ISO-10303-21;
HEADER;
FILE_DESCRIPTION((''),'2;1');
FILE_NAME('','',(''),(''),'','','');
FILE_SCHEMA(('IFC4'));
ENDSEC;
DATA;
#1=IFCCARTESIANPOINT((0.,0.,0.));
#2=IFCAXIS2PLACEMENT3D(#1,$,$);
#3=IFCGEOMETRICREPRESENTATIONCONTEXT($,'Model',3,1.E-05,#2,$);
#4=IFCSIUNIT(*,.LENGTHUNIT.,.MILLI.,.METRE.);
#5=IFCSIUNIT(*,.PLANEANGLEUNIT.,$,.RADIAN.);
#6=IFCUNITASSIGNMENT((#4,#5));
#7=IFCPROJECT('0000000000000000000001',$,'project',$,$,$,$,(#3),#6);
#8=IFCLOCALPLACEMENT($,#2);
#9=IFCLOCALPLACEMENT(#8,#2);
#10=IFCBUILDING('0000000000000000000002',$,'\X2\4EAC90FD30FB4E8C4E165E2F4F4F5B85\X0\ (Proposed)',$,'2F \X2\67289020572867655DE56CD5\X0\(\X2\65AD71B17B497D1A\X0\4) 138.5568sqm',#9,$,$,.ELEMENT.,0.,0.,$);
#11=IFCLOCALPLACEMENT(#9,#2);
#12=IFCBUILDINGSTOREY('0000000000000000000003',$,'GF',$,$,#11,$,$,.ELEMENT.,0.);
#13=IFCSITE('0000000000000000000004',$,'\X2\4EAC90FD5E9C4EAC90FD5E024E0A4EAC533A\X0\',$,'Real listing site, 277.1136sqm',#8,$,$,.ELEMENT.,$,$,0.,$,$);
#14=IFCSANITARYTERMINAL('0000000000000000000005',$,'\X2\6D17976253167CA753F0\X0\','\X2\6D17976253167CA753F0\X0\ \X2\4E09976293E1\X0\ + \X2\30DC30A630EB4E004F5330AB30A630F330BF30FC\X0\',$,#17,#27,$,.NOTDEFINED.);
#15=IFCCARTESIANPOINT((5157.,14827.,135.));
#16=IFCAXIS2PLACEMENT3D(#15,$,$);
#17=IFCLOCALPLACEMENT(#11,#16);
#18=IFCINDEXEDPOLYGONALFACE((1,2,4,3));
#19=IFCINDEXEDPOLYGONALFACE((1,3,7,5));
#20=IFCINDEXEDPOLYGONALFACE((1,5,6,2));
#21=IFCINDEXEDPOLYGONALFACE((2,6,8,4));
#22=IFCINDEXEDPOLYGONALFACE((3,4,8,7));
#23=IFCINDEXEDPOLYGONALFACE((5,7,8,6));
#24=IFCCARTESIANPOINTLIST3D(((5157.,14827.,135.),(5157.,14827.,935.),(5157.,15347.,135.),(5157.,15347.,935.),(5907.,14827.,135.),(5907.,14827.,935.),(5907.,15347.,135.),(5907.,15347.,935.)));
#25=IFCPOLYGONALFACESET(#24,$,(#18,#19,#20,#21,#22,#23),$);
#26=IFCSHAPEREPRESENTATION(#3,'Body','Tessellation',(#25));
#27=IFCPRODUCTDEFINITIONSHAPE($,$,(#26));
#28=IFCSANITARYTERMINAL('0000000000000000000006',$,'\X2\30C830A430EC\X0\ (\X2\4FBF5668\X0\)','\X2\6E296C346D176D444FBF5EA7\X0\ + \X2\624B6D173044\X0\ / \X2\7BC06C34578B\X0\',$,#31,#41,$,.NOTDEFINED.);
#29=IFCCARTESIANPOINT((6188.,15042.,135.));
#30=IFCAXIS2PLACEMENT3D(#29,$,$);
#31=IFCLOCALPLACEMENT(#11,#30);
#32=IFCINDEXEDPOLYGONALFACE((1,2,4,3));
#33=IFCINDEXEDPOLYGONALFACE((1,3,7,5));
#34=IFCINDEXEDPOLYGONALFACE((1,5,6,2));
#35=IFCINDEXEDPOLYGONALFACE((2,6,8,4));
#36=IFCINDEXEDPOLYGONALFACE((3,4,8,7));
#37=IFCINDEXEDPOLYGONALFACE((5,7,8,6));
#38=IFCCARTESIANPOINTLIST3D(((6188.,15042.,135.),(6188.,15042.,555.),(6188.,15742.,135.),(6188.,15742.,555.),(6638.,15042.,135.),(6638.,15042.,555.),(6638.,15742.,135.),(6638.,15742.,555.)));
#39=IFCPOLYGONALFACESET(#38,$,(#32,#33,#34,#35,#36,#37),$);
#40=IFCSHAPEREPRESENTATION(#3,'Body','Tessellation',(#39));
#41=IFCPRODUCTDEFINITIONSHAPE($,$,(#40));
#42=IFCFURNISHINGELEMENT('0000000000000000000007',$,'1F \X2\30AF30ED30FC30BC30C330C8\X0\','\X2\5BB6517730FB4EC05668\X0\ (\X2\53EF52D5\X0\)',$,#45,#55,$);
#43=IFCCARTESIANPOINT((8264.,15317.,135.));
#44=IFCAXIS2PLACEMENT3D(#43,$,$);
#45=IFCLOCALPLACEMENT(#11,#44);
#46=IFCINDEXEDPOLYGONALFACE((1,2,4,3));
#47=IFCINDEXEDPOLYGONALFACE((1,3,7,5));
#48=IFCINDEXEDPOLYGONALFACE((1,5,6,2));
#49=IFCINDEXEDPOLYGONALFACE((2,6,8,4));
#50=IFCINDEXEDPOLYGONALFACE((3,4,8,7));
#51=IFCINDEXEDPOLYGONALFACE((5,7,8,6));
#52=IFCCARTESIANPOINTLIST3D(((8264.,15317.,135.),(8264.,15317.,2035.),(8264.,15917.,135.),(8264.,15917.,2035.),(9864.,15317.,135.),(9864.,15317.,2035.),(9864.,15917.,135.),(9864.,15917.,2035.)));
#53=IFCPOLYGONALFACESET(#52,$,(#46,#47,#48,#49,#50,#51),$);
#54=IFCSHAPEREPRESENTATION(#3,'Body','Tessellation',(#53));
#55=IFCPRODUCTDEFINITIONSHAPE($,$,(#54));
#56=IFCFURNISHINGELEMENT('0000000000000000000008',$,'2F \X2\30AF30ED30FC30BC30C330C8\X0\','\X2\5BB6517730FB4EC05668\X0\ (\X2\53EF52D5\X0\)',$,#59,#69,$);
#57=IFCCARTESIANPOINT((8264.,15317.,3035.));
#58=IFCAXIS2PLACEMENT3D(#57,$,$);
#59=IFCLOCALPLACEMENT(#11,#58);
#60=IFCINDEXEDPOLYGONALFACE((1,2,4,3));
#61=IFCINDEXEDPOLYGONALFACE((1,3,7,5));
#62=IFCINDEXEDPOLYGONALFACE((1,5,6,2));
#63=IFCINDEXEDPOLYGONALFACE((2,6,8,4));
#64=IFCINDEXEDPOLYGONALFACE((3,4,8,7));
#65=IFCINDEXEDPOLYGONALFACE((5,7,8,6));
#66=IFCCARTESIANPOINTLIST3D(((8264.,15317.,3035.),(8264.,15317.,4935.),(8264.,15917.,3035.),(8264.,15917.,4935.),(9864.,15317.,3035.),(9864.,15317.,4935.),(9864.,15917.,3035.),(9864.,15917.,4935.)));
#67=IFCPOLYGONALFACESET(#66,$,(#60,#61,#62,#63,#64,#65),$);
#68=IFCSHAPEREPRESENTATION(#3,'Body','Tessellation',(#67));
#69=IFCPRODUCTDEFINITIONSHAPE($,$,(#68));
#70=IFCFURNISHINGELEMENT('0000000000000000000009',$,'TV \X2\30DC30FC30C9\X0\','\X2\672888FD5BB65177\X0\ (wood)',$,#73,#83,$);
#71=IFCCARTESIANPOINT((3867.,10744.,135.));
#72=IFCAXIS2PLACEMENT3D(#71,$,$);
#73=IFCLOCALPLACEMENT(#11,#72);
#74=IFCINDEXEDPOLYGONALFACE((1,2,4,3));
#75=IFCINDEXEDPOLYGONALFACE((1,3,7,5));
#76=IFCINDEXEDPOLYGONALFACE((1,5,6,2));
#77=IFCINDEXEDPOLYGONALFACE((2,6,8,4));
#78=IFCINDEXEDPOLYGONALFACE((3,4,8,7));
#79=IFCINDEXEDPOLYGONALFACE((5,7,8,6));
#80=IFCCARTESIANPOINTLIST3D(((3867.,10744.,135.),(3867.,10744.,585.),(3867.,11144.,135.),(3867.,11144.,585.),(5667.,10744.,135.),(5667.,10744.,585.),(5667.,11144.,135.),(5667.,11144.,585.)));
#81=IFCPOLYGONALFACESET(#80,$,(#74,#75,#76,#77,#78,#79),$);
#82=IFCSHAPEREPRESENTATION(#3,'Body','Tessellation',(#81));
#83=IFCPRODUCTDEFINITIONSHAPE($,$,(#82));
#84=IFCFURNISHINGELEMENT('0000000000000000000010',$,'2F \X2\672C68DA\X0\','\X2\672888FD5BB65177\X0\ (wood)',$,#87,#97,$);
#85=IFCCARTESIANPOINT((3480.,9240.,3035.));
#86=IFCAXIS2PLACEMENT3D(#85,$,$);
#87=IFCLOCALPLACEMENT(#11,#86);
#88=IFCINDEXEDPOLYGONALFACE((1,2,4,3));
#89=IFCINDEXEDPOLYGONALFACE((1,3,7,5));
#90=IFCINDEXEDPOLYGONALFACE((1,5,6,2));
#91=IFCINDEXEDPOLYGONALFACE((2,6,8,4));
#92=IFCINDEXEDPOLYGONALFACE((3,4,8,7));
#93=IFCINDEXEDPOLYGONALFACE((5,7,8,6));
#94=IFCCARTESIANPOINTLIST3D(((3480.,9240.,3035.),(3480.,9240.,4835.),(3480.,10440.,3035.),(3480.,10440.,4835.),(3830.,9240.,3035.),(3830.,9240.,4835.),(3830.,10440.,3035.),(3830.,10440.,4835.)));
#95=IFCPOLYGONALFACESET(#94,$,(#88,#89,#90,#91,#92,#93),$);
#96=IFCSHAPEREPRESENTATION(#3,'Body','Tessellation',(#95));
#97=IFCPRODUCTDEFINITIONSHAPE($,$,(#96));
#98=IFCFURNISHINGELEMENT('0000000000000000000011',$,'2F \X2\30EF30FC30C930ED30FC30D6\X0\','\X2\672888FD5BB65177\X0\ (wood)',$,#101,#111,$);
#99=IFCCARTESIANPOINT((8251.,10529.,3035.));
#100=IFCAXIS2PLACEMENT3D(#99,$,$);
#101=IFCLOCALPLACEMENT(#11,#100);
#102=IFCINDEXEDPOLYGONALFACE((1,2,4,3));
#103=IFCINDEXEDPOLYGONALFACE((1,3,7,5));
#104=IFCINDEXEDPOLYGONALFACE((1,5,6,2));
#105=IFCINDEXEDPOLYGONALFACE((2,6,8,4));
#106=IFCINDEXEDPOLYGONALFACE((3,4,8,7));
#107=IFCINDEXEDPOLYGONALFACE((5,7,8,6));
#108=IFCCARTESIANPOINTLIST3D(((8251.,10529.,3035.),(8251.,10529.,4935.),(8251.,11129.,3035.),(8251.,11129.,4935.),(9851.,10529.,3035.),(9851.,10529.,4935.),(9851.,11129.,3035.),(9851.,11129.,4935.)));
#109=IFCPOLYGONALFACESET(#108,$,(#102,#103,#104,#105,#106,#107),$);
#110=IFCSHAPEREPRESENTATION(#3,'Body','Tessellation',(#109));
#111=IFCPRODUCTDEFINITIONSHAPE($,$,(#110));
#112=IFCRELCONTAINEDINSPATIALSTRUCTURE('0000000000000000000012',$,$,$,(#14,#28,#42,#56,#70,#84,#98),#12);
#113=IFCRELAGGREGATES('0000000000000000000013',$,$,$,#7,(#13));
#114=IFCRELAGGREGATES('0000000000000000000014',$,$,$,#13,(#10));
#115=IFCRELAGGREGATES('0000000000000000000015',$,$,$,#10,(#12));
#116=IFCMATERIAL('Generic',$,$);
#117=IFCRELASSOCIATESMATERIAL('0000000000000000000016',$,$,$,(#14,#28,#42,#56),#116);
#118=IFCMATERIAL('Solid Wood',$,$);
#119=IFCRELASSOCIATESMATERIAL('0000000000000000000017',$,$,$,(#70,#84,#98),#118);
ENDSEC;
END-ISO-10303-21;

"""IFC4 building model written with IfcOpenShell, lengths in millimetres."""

from ifc_helpers import new_model, si_unit, frame, frame_2d, origin, place, context, project, spatial, rectangle, extrude, material, element, save


model = new_model("IFC4")

# Units and contexts
model_context = context("Model", 3, precision=1e-05, world=origin())
ifc_project = project(units=[si_unit("LENGTHUNIT", "METRE", prefix="MILLI"), si_unit("PLANEANGLEUNIT", "RADIAN")], contexts=[model_context])

# Site, building, storey
site_placement = place(None, origin())
site = spatial("IfcSite", under=ifc_project, at=site_placement, Name="京都府京都市上京区", ObjectType="Real listing site, 277.1136sqm", CompositionType="ELEMENT", RefElevation=0.0)
building_placement = place(site_placement, origin())
building = spatial("IfcBuilding", under=site, at=building_placement, Name="京都・二世帯住宅 (Proposed)", ObjectType="2F 木造在来工法(断熱等級4) 138.5568sqm", CompositionType="ELEMENT", ElevationOfRefHeight=0.0, ElevationOfTerrain=0.0)
storey_placement = place(building_placement, origin())
storey = spatial("IfcBuildingStorey", under=building, at=storey_placement, Name="GF", CompositionType="ELEMENT", Elevation=0.0)

# Shared definitions
ifc_material_1 = material(Name="Solid Wood")

# Sanitary terminals
ifc_material_2 = material(Name="Generic")
sanitary_terminal_1_placement = place(storey_placement, frame((5157.0, 14827.0, 135.0)))
element("IfcSanitaryTerminal", 1, at=sanitary_terminal_1_placement, inside=storey, material=ifc_material_2, Name="洗面化粧台", Description="洗面化粧台 三面鏡 + ボウル一体カウンター", PredefinedType="NOTDEFINED", context=model_context, shape_type="SweptSolid", body=[
    extrude(rectangle(XDim=750.0, YDim=520.0, at=frame_2d((375.0, 260.0))), frame((5157.0, 14827.0, 135.0)), (0.0, 0.0, 1.0), 800.0),
])
sanitary_terminal_2_placement = place(storey_placement, frame((6188.0, 15042.0, 135.0)))
element("IfcSanitaryTerminal", 2, at=sanitary_terminal_2_placement, inside=storey, material=ifc_material_2, Name="トイレ (便器)", Description="温水洗浄便座 + 手洗い / 節水型", PredefinedType="NOTDEFINED", context=model_context, shape_type="SweptSolid", body=[
    extrude(rectangle(XDim=450.0, YDim=700.0, at=frame_2d((225.0, 350.0))), frame((6188.0, 15042.0, 135.0)), (0.0, 0.0, 1.0), 420.0),
])

# Furnishing elements
furnishing_1_placement = place(storey_placement, frame((8264.0, 15317.0, 135.0)))
element("IfcFurnishingElement", 3, at=furnishing_1_placement, inside=storey, material=ifc_material_2, Name="1F クローゼット", Description="家具・什器 (可動)", context=model_context, shape_type="SweptSolid", body=[
    extrude(rectangle(XDim=1600.0, YDim=600.0, at=frame_2d((800.0, 300.0))), frame((8264.0, 15317.0, 135.0)), (0.0, 0.0, 1.0), 1900.0),
])
furnishing_2_placement = place(storey_placement, frame((8264.0, 15317.0, 3035.0)))
element("IfcFurnishingElement", 4, at=furnishing_2_placement, inside=storey, material=ifc_material_2, Name="2F クローゼット", Description="家具・什器 (可動)", context=model_context, shape_type="SweptSolid", body=[
    extrude(rectangle(XDim=1600.0, YDim=600.0, at=frame_2d((800.0, 300.0))), frame((8264.0, 15317.0, 3035.0)), (0.0, 0.0, 1.0), 1900.0),
])
furnishing_3_placement = place(storey_placement, frame((3867.0, 10744.0, 135.0)))
element("IfcFurnishingElement", 5, at=furnishing_3_placement, inside=storey, material=ifc_material_1, Name="TV ボード", Description="木製家具 (wood)", context=model_context, shape_type="SweptSolid", body=[
    extrude(rectangle(XDim=1800.0, YDim=400.0, at=frame_2d((900.0, 200.0))), frame((3867.0, 10744.0, 135.0)), (0.0, 0.0, 1.0), 450.0),
])
furnishing_4_placement = place(storey_placement, frame((3480.0, 9240.0, 3035.0)))
element("IfcFurnishingElement", 6, at=furnishing_4_placement, inside=storey, material=ifc_material_1, Name="2F 本棚", Description="木製家具 (wood)", context=model_context, shape_type="SweptSolid", body=[
    extrude(rectangle(XDim=350.0, YDim=1200.0, at=frame_2d((175.0, 600.0))), frame((3480.0, 9240.0, 3035.0)), (0.0, 0.0, 1.0), 1800.0),
])
furnishing_5_placement = place(storey_placement, frame((8251.0, 10529.0, 3035.0)))
element("IfcFurnishingElement", 7, at=furnishing_5_placement, inside=storey, material=ifc_material_1, Name="2F ワードローブ", Description="木製家具 (wood)", context=model_context, shape_type="SweptSolid", body=[
    extrude(rectangle(XDim=1600.0, YDim=600.0, at=frame_2d((800.0, 300.0))), frame((8251.0, 10529.0, 3035.0)), (0.0, 0.0, 1.0), 1900.0),
])

save(model, "model.ifc")
